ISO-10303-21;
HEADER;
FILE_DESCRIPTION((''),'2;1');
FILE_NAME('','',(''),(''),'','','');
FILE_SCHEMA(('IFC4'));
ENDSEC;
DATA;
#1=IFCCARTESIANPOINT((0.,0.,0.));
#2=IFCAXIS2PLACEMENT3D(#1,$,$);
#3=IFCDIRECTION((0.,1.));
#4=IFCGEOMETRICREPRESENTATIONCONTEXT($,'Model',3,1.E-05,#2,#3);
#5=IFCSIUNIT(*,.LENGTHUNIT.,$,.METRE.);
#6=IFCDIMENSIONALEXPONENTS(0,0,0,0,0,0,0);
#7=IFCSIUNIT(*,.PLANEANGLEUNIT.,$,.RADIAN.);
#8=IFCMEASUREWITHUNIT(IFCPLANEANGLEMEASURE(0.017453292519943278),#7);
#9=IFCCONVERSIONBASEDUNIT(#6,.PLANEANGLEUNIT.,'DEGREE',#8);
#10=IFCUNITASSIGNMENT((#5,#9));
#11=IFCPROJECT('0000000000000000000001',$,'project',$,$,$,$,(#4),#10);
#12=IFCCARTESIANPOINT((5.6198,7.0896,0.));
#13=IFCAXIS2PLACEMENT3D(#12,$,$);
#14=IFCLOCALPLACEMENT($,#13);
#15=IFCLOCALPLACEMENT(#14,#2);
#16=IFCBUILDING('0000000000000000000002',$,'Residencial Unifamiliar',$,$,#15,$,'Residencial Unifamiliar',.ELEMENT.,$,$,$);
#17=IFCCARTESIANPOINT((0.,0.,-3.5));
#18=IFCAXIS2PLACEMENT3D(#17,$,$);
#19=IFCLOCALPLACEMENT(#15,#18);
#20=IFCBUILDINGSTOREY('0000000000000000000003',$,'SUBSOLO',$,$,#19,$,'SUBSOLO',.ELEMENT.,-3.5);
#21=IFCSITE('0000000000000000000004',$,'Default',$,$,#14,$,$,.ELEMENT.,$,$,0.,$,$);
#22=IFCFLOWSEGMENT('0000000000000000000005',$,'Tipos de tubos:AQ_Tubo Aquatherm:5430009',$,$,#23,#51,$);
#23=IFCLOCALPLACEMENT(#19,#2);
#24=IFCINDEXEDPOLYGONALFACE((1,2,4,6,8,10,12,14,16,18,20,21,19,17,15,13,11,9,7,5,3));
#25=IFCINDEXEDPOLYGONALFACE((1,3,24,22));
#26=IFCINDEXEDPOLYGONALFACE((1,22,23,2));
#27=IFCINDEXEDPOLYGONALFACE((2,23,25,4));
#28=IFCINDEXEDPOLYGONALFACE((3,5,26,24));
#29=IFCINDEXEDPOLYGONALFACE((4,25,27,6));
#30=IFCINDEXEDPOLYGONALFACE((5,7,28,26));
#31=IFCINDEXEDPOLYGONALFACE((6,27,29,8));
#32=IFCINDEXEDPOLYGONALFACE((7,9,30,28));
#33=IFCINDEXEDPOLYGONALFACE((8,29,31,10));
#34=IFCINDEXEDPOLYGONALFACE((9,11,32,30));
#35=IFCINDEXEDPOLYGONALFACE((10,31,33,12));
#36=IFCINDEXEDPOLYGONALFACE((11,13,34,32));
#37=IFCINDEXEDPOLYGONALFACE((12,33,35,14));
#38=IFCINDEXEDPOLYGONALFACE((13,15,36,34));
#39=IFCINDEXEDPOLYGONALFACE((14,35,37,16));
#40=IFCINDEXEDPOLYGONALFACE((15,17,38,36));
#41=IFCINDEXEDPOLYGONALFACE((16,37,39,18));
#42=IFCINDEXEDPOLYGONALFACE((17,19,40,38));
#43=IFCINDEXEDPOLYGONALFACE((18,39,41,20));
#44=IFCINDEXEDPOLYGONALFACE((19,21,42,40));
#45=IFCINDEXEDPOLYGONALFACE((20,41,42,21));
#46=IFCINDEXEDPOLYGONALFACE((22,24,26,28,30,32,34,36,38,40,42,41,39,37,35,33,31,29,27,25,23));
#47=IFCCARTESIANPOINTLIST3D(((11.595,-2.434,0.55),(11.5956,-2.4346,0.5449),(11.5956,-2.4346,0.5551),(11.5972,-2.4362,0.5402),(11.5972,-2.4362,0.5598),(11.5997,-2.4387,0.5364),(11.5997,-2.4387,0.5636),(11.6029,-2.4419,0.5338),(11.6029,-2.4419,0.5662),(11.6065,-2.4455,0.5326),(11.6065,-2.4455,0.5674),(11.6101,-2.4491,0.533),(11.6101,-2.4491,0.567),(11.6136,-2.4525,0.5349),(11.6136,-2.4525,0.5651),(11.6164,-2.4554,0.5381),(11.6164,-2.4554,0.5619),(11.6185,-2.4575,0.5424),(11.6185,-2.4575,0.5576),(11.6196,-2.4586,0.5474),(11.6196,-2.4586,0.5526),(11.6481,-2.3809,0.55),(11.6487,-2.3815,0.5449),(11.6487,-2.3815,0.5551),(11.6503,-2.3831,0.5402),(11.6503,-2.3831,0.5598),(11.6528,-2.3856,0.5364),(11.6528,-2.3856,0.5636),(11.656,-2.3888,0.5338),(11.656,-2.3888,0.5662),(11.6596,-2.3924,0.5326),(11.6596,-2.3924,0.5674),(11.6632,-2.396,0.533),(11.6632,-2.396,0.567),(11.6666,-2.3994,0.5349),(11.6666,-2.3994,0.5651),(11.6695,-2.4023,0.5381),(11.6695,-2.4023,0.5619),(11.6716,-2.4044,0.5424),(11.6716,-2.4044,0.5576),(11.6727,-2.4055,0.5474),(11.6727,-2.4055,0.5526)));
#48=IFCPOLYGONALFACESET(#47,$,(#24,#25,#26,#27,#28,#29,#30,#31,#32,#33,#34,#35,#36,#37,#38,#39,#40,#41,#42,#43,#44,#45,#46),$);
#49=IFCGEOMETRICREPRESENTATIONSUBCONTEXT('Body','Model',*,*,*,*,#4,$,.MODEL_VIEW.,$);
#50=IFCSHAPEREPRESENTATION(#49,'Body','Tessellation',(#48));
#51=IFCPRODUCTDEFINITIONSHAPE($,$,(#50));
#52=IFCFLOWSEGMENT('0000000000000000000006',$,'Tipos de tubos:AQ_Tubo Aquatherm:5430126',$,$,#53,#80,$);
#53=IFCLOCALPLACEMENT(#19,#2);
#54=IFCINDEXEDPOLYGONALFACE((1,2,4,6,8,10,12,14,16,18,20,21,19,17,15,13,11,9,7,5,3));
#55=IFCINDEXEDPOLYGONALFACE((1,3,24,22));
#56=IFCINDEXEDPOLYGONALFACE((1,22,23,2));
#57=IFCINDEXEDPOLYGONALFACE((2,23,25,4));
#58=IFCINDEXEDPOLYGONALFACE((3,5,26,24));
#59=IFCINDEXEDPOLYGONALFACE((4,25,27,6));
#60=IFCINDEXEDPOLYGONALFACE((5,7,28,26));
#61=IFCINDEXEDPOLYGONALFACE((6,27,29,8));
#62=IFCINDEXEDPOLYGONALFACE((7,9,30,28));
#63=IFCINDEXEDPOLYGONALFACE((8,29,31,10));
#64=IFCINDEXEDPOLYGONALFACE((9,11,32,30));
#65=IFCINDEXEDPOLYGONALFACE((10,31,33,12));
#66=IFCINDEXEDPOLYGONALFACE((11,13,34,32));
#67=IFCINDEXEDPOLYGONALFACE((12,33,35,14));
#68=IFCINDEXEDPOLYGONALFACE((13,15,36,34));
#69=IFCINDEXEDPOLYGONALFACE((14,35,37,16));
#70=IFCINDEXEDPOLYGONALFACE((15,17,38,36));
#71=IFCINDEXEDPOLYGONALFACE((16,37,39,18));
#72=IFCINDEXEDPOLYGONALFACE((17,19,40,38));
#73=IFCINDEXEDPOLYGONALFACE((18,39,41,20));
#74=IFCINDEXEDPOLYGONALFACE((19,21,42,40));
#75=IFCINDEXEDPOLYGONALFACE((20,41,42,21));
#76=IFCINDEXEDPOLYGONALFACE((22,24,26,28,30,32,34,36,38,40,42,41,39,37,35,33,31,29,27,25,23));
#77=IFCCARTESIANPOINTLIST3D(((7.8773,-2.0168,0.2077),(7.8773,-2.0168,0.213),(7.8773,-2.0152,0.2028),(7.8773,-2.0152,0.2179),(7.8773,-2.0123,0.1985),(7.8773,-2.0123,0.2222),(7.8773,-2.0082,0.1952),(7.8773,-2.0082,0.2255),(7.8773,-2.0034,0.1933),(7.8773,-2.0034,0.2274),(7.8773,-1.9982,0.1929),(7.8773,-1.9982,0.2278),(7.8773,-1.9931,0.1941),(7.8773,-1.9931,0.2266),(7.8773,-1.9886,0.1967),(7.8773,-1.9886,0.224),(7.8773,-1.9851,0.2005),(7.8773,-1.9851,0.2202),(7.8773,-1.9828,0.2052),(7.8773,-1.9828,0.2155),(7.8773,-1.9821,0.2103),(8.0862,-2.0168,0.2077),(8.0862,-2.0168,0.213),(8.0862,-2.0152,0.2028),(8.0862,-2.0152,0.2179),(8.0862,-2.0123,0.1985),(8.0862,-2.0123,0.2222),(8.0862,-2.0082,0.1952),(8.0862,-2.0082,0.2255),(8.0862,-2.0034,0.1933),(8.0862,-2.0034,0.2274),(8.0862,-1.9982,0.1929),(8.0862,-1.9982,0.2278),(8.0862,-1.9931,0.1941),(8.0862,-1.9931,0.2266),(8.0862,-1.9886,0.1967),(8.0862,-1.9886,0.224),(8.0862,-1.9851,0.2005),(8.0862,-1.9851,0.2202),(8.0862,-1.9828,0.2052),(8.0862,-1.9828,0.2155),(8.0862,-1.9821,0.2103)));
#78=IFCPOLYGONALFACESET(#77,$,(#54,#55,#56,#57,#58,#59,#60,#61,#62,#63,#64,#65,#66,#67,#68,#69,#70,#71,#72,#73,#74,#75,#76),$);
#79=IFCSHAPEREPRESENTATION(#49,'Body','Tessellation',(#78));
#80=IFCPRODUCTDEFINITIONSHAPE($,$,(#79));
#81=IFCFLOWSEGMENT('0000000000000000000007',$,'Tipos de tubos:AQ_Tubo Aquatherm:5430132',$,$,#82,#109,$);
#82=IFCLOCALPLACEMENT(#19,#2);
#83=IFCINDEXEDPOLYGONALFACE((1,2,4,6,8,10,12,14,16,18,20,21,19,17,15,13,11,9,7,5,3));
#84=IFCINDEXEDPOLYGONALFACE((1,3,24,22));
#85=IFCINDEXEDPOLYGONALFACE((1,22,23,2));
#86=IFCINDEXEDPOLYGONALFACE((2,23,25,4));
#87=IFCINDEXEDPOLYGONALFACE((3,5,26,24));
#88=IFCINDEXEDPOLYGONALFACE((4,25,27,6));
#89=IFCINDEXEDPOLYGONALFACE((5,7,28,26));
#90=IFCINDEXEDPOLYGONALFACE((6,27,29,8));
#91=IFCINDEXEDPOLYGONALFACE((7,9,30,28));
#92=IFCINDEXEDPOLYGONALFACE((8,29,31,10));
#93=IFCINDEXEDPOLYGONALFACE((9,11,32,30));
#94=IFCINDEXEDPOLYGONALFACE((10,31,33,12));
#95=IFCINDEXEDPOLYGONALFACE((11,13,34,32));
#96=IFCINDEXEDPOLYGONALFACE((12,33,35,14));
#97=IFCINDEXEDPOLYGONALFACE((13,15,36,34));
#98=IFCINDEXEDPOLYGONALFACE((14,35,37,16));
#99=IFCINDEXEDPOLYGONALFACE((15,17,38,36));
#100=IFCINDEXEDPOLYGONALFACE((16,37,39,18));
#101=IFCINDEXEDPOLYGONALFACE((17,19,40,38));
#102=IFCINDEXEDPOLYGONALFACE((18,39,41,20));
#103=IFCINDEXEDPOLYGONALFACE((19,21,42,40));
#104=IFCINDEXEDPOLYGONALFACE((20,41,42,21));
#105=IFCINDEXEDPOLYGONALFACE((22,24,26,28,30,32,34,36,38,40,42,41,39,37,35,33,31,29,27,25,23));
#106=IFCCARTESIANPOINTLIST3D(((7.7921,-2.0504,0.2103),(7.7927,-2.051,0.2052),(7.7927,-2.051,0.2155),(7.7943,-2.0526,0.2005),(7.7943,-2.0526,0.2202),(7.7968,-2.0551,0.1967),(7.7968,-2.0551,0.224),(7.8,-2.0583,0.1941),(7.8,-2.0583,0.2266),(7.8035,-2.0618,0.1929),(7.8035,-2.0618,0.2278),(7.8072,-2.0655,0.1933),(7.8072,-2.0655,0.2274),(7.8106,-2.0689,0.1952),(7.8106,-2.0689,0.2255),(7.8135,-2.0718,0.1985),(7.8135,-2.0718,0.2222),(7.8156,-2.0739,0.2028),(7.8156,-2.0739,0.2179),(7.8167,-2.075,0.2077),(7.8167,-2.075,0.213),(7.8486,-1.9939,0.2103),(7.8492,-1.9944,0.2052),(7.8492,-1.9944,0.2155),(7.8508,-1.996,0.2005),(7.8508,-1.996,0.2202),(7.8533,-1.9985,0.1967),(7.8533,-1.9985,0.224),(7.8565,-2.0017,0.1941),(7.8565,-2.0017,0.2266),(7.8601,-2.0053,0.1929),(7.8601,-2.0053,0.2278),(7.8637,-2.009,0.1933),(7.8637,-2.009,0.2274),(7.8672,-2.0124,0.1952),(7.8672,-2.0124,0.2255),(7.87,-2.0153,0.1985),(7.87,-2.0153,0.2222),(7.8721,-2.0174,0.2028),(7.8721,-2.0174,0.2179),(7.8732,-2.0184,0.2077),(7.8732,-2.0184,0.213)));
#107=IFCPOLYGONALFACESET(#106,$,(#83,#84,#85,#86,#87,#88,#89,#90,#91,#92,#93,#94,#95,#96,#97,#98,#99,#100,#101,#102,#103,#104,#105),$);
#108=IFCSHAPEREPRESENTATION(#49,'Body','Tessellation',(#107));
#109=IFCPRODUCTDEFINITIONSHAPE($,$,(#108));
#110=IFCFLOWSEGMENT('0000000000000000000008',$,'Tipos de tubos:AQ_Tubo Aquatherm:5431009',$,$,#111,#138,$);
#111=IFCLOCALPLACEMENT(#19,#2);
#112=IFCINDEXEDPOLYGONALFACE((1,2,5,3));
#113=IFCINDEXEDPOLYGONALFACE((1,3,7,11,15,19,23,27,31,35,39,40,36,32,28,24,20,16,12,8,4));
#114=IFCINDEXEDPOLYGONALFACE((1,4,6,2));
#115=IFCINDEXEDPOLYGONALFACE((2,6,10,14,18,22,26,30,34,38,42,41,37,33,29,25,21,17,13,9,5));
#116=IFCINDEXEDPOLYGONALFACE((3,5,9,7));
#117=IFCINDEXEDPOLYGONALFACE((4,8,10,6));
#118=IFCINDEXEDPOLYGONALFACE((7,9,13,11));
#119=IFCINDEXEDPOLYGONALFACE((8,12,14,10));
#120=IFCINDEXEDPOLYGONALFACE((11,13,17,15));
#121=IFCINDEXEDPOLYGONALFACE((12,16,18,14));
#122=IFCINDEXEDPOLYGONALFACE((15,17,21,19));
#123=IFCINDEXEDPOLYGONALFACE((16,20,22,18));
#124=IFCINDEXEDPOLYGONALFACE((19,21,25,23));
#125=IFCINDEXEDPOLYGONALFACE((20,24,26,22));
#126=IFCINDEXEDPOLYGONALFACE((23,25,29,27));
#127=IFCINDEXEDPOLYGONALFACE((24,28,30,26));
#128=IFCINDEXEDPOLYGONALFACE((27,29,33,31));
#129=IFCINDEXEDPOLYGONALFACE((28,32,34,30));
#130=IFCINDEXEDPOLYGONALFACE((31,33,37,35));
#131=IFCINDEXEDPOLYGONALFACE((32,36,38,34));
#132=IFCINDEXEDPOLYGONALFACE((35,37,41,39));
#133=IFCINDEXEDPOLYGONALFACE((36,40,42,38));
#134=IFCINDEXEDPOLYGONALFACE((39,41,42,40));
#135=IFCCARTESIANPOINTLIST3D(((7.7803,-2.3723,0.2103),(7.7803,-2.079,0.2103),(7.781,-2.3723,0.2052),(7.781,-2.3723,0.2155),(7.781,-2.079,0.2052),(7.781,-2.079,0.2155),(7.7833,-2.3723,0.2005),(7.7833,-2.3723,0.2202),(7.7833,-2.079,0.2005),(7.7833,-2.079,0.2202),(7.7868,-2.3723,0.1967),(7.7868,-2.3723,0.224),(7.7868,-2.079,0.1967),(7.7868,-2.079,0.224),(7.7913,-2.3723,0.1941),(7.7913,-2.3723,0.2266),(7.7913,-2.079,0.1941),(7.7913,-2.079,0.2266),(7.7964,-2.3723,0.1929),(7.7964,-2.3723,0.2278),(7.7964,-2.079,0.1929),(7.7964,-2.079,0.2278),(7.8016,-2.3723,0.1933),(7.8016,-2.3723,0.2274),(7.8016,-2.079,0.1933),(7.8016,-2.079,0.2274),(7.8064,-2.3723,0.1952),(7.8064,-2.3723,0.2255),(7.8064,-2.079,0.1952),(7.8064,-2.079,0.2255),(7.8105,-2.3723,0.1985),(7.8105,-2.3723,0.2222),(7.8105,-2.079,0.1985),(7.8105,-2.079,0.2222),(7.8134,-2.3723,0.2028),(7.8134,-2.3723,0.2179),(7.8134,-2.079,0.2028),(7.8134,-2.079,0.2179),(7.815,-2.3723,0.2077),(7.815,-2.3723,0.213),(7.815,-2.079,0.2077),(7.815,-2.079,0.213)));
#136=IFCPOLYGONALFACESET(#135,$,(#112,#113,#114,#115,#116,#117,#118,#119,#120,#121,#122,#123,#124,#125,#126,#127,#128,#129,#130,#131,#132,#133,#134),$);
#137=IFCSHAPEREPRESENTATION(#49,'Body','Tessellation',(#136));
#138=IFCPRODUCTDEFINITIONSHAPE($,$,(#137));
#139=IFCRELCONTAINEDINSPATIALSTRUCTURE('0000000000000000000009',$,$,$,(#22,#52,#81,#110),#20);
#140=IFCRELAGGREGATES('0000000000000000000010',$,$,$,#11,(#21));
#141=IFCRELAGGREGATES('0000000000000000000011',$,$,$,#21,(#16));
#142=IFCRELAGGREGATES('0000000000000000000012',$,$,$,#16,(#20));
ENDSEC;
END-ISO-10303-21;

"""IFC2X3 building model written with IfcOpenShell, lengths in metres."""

from ifc_helpers import new_model, entity, si_unit, converted_unit, direction, frame, origin, origin_2d_with_axis, place, context, subcontext, project, spatial, circle, extrude, element, save


model = new_model("IFC2X3")

# Units and contexts
model_context = context("Model", 3, precision=1e-05, world=origin(), true_north=direction((0.0, 1.0)))
body_context = subcontext(model_context, "Body", "Model", "MODEL_VIEW")
ifc_project = project(units=[si_unit("LENGTHUNIT", "METRE"), converted_unit("PLANEANGLEUNIT", "DEGREE", entity("IfcPlaneAngleMeasure", 0.017453292519943278), si_unit("PLANEANGLEUNIT", "RADIAN"), dimensions=[0, 0, 0, 0, 0, 0, 0])], contexts=[model_context])

# Site, building, storey
site_placement = place(None, frame((5.6198, 7.0896, 0.0)))
site = spatial("IfcSite", under=ifc_project, at=site_placement, Name="Default", CompositionType="ELEMENT", RefElevation=0.0)
building_placement = place(site_placement, origin())
building = spatial("IfcBuilding", under=site, at=building_placement, Name="Residencial Unifamiliar", LongName="Residencial Unifamiliar", CompositionType="ELEMENT")
storey_placement = place(building_placement, frame((0.0, 0.0, -3.5)))
storey = spatial("IfcBuildingStorey", under=building, at=storey_placement, Name="SUBSOLO", LongName="SUBSOLO", CompositionType="ELEMENT", Elevation=-3.5)

# Flow segments
flow_segment_1_placement = place(storey_placement, origin())
element("IfcFlowSegment", 1, at=flow_segment_1_placement, inside=storey, Name="Tipos de tubos:AQ_Tubo Aquatherm:5430009", context=body_context, shape_type="SweptSolid", body=[
    extrude(circle(Radius=0.0175, at=origin_2d_with_axis()), frame((11.6074, -2.4464, 0.55), z_axis=(0.707107, 0.707107, 0.0), x_axis=(-0.707107, 0.707107, 0.0)), (0.0, 0.0, 1.0), 0.0751),
])
flow_segment_2_placement = place(storey_placement, origin())
element("IfcFlowSegment", 2, at=flow_segment_2_placement, inside=storey, Name="Tipos de tubos:AQ_Tubo Aquatherm:5430126", context=body_context, shape_type="SweptSolid", body=[
    extrude(circle(Radius=0.0175, at=origin_2d_with_axis()), frame((7.8773, -1.9995, 0.2103), z_axis=(1.0, 0.0, 0.0), x_axis=(0.0, 1.0, 0.0)), (0.0, 0.0, 1.0), 0.2089),
])
flow_segment_3_placement = place(storey_placement, origin())
element("IfcFlowSegment", 3, at=flow_segment_3_placement, inside=storey, Name="Tipos de tubos:AQ_Tubo Aquatherm:5430132", context=body_context, shape_type="SweptSolid", body=[
    extrude(circle(Radius=0.0175, at=origin_2d_with_axis()), frame((7.8045, -2.0628, 0.2103), z_axis=(0.707107, 0.707107, 0.0), x_axis=(-0.707107, 0.707107, 0.0)), (0.0, 0.0, 1.0), 0.0799),
])
flow_segment_4_placement = place(storey_placement, origin())
element("IfcFlowSegment", 4, at=flow_segment_4_placement, inside=storey, Name="Tipos de tubos:AQ_Tubo Aquatherm:5431009", context=body_context, shape_type="SweptSolid", body=[
    extrude(circle(Radius=0.0175, at=origin_2d_with_axis()), frame((7.7977, -2.3723, 0.2103), z_axis=(0.0, 1.0, 0.0), x_axis=(-1.0, 0.0, 0.0)), (0.0, 0.0, 1.0), 0.2933),
])

save(model, "model.ifc")
